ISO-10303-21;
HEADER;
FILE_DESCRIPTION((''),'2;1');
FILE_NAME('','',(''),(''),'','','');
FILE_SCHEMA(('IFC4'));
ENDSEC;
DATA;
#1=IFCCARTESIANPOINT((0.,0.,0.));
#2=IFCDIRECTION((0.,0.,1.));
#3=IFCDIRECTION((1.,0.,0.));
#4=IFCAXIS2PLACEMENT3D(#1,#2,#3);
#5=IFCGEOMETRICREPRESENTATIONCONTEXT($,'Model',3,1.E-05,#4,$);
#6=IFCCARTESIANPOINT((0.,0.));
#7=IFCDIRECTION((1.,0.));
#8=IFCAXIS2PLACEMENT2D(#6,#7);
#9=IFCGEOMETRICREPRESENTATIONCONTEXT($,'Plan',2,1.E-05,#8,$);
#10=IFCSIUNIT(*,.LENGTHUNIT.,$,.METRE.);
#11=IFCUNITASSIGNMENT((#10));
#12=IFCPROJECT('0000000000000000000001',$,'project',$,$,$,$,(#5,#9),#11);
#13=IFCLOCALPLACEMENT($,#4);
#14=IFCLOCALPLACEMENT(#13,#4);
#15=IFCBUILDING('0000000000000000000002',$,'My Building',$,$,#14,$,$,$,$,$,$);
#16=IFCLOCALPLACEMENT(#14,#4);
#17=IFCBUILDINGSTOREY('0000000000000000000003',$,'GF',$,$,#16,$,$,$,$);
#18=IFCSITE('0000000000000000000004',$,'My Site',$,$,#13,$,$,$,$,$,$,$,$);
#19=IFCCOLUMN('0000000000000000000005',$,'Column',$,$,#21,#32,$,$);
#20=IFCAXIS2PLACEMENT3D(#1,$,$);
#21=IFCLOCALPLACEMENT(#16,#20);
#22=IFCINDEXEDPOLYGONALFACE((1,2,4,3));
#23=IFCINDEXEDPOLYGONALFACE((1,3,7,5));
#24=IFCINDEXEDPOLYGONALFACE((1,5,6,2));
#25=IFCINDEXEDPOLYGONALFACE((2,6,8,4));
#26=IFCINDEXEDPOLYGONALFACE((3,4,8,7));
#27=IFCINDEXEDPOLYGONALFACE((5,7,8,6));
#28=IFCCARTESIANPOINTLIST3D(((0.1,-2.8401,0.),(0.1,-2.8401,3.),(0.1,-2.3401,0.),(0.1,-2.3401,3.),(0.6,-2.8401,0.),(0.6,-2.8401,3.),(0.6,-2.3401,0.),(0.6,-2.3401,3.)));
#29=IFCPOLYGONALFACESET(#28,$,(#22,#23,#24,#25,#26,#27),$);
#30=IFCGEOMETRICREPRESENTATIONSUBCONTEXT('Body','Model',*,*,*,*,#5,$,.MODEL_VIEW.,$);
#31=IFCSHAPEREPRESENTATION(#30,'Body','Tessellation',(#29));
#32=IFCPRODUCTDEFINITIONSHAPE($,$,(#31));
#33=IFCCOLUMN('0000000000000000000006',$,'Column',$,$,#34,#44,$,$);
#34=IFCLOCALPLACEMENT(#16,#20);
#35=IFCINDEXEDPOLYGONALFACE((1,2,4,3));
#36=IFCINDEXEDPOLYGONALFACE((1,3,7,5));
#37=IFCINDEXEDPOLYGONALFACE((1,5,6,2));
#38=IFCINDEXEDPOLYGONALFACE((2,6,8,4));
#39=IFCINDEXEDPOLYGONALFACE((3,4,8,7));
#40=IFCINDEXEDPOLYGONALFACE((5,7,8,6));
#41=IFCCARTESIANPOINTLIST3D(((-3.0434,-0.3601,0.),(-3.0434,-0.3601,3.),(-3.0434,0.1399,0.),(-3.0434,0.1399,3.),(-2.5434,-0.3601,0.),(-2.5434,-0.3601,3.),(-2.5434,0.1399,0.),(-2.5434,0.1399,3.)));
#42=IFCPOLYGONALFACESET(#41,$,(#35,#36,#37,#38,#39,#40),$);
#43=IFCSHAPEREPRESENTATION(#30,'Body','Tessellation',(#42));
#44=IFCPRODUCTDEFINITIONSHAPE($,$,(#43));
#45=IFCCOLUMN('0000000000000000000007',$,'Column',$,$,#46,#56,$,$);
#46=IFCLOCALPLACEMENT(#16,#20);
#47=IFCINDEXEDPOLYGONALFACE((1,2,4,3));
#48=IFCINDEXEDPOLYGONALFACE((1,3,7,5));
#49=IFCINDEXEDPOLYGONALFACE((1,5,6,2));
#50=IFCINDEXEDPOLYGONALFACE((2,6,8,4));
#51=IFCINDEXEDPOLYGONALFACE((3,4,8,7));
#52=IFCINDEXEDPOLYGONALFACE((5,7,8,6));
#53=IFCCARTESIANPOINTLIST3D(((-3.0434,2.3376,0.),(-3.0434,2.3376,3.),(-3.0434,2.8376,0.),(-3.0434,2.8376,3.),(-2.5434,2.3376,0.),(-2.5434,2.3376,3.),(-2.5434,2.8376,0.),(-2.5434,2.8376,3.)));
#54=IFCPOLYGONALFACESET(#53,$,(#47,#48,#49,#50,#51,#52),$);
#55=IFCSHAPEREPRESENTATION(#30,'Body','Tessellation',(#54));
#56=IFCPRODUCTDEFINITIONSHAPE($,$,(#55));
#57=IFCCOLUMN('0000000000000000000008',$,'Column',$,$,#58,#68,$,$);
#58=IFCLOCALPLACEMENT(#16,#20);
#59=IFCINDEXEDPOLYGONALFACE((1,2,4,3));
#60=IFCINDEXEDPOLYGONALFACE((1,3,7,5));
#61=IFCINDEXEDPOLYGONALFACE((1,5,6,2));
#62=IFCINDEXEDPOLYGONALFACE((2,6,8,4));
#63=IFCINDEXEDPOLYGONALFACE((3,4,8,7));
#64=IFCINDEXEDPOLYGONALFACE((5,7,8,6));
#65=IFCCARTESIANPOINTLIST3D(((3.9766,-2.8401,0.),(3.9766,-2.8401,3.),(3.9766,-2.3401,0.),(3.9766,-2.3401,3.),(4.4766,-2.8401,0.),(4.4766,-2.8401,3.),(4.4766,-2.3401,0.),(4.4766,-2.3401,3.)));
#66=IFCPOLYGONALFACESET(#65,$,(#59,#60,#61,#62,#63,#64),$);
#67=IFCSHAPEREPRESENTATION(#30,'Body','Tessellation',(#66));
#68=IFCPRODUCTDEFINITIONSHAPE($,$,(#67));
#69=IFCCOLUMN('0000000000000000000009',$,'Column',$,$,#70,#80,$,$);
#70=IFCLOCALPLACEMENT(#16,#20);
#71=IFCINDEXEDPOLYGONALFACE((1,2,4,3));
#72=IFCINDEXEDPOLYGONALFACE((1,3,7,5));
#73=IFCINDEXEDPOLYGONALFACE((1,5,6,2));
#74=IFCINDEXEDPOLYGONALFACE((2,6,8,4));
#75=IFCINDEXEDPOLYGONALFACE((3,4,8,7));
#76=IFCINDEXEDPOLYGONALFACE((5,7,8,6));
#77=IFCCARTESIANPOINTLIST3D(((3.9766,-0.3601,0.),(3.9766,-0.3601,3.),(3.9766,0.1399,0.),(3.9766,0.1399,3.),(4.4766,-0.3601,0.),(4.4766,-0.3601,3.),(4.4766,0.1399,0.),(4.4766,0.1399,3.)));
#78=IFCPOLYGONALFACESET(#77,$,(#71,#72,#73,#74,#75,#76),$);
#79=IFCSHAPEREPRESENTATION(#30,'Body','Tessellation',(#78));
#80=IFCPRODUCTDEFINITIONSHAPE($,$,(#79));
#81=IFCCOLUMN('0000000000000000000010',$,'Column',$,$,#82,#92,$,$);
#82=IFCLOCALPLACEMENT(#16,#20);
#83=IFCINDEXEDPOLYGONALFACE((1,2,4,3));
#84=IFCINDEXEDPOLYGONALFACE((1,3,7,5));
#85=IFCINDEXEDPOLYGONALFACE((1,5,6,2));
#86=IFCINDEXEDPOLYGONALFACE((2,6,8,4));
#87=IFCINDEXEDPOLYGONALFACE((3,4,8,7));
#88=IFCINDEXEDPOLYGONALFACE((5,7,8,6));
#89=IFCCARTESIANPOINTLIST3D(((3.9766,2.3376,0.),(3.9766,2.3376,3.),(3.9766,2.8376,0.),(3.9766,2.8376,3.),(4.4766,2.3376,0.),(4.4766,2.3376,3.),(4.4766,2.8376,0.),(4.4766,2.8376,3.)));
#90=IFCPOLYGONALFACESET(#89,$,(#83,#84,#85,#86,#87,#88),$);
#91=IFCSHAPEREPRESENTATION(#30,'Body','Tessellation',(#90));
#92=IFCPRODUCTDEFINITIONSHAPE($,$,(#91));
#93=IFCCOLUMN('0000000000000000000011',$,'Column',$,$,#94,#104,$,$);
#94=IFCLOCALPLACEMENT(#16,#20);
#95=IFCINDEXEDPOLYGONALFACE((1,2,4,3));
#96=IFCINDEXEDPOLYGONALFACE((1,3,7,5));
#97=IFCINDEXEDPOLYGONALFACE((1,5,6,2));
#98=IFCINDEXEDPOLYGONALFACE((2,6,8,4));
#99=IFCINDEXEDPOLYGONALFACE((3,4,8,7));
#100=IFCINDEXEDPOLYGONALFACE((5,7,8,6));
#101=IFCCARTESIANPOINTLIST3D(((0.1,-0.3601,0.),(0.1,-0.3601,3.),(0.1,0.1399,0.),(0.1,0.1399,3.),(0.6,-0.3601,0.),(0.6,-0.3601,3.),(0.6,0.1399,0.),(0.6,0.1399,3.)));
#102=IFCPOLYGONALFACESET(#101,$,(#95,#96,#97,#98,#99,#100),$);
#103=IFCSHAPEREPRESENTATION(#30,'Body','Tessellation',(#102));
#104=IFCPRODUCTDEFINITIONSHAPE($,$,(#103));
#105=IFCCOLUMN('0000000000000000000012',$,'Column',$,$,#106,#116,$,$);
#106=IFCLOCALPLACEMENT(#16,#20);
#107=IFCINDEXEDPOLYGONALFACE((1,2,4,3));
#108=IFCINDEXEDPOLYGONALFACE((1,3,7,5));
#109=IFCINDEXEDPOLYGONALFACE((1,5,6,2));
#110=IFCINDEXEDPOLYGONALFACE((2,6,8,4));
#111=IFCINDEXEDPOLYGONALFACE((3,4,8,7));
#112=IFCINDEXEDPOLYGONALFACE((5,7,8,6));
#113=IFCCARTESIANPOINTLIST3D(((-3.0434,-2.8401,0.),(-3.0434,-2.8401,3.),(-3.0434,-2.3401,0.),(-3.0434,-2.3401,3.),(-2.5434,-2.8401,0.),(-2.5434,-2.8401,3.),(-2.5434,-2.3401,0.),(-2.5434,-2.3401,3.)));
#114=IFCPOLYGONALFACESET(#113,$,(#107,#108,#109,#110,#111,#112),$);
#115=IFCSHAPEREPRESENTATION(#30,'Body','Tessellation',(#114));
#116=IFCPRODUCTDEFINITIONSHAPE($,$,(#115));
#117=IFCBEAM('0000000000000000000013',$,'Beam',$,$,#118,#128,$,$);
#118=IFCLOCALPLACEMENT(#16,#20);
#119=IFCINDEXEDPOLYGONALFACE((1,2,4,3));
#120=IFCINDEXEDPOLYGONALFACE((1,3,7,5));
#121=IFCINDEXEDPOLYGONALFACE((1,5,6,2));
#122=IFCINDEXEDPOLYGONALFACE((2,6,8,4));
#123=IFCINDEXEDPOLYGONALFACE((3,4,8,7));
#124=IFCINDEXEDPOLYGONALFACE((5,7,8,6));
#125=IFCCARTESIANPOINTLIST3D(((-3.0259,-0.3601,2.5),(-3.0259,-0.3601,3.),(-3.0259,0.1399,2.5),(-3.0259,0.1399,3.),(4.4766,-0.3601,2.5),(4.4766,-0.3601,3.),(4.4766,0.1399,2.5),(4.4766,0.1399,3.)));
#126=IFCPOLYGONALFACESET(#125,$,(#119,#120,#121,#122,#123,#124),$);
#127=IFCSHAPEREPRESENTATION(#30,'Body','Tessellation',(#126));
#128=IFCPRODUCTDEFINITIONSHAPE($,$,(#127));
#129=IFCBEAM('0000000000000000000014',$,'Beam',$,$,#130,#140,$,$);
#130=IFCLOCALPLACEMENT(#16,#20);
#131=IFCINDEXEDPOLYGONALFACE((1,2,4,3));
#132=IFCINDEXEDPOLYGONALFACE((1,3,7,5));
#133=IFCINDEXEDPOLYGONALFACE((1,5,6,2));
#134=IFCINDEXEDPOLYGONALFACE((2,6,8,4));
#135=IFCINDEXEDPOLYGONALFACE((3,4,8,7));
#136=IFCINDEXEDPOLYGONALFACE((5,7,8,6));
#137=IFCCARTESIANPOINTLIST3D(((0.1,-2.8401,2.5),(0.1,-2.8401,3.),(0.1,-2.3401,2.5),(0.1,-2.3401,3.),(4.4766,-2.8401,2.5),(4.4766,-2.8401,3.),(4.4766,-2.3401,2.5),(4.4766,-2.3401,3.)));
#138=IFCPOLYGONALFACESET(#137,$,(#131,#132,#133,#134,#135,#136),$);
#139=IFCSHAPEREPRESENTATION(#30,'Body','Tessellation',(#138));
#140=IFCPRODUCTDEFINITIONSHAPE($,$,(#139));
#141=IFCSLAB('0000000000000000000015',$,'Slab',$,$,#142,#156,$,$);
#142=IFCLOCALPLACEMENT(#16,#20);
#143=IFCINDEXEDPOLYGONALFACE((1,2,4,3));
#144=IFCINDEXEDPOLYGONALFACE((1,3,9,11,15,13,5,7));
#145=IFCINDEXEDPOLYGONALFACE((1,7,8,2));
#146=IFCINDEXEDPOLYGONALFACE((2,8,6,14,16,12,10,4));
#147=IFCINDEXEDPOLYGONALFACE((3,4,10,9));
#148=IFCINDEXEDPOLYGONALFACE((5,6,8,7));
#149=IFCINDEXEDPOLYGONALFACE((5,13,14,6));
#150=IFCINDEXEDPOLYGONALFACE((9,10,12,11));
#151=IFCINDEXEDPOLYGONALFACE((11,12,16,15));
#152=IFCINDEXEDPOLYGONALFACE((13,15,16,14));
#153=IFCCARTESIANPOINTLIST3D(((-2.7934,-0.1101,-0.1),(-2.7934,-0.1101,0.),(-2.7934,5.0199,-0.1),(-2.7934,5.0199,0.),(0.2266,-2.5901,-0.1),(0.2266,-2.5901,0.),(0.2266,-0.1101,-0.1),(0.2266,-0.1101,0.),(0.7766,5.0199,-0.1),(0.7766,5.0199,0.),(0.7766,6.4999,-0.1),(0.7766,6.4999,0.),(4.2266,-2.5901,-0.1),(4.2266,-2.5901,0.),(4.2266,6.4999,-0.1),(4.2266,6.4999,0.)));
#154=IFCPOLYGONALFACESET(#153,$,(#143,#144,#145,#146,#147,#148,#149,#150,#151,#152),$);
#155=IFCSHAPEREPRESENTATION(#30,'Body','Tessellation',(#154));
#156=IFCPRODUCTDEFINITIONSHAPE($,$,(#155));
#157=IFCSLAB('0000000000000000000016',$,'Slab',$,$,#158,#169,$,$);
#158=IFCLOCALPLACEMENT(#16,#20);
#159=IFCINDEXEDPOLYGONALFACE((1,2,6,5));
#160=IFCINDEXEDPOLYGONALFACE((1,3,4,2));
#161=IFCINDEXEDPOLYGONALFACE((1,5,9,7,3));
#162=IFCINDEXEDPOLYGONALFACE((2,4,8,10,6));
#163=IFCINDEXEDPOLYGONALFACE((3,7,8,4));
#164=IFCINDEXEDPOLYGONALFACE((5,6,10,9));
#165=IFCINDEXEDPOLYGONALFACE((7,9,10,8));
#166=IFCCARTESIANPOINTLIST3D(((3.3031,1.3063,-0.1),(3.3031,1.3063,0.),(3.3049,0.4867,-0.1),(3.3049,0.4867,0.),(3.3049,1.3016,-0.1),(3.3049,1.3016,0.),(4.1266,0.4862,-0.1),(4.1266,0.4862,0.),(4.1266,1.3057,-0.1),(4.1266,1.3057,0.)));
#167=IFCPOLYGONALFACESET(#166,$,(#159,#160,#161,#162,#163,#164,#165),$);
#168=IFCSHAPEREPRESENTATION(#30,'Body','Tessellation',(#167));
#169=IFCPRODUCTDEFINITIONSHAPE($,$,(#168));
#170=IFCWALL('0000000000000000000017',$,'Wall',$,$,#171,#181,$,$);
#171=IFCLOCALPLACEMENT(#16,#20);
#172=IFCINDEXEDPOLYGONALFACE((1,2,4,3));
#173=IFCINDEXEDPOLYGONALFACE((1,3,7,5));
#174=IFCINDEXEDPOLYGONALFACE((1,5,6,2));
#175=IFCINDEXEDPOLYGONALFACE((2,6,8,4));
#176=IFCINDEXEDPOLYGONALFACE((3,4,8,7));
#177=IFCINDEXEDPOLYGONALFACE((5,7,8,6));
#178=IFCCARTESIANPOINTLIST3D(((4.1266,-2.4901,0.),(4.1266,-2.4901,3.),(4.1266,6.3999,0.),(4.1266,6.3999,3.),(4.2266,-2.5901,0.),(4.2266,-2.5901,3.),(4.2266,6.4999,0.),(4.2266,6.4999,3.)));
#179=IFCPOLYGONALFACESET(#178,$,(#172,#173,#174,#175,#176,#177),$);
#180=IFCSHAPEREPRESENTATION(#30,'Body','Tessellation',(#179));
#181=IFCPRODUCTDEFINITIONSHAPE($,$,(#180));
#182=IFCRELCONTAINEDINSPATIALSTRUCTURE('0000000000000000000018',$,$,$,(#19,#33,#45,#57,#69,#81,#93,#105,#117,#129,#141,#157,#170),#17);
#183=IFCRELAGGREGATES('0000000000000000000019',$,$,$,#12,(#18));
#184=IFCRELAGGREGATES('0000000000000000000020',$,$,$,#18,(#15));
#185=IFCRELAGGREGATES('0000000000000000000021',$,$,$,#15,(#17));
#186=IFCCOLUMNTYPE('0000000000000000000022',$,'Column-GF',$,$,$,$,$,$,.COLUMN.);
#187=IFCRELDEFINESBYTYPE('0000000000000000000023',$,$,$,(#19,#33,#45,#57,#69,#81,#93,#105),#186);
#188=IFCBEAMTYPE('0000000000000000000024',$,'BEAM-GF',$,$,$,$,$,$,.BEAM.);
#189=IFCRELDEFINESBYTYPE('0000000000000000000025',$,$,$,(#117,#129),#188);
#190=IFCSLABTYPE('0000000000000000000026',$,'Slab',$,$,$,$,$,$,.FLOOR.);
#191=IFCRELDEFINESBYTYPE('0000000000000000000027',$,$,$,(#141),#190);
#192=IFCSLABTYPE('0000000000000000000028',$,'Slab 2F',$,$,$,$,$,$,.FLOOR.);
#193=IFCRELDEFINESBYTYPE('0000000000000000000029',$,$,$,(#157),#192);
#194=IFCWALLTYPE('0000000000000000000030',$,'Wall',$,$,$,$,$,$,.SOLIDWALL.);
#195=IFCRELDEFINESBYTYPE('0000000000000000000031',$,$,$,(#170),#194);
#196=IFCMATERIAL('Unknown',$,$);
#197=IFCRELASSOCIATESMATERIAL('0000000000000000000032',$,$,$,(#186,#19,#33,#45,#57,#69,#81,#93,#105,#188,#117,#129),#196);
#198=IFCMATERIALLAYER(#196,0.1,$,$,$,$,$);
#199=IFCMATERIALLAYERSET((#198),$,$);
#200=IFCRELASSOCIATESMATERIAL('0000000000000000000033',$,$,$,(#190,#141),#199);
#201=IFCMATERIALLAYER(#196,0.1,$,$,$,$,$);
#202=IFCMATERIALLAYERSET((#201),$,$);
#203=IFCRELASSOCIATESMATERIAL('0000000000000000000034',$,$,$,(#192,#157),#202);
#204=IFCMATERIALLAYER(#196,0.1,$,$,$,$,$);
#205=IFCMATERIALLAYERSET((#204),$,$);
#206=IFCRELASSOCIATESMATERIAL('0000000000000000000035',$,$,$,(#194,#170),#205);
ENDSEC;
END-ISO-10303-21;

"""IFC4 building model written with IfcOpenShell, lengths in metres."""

from ifc_helpers import new_model, si_unit, frame, origin_with_axes, origin_2d_with_axis, place, context, subcontext, project, spatial, line, indexed_curve, rectangle, outline, extrude, material, layer, layer_set, layer_usage, material_profile, profile_set, profile_usage, type_object, element, save


model = new_model("IFC4")

# Units and contexts
model_context = context("Model", 3, precision=1e-05, world=origin_with_axes())
plan_context = context("Plan", 2, precision=1e-05, world=origin_2d_with_axis())
body_context_1 = subcontext(model_context, "Body", "Model", "MODEL_VIEW")
ifc_project = project(units=[si_unit("LENGTHUNIT", "METRE")], contexts=[model_context, plan_context])

# Site, building, storey
site_placement = place(None, origin_with_axes())
site = spatial("IfcSite", under=ifc_project, at=site_placement, Name="My Site")
building_placement = place(site_placement, origin_with_axes())
building = spatial("IfcBuilding", under=site, at=building_placement, Name="My Building")
storey_placement = place(building_placement, origin_with_axes())
storey = spatial("IfcBuildingStorey", under=building, at=storey_placement, Name="GF")

# Columns
ifc_material = material(Name="Unknown")
ifc_material_profile_1 = material_profile(ifc_material, rectangle(XDim=0.5, YDim=0.5))
ifc_profile_set_1 = profile_set([ifc_material_profile_1])
ifc_profile_usage_1 = profile_usage(ifc_profile_set_1, cardinal=5)
column_type = type_object("IfcColumnType", Name="Column-GF", PredefinedType="COLUMN", material=ifc_profile_set_1)
column_1_placement = place(storey_placement, frame((0.35, -2.5901, 0.0), z_axis=(0.0, 0.0, 1.0), x_axis=(1.0, 0.0, 0.0)))
element("IfcColumn", 1, at=column_1_placement, inside=storey, type_object=column_type, material=ifc_profile_usage_1, Name="Column", context=body_context_1, shape_type="SweptSolid", body=[
    extrude(rectangle(XDim=0.5, YDim=0.5), origin_with_axes(), (0.0, 0.0, 1.0), 3.0),
])
ifc_profile_usage_2 = profile_usage(ifc_profile_set_1, cardinal=5)
column_2_placement = place(storey_placement, frame((-2.7934, -0.1101, 0.0), z_axis=(0.0, 0.0, 1.0), x_axis=(1.0, 0.0, 0.0)))
element("IfcColumn", 2, at=column_2_placement, inside=storey, type_object=column_type, material=ifc_profile_usage_2, Name="Column", context=body_context_1, shape_type="SweptSolid", body=[
    extrude(rectangle(XDim=0.5, YDim=0.5), origin_with_axes(), (0.0, 0.0, 1.0), 3.0),
])
ifc_profile_usage_3 = profile_usage(ifc_profile_set_1, cardinal=5)
column_3_placement = place(storey_placement, frame((-2.7934, 2.5876, 0.0), z_axis=(0.0, 0.0, 1.0), x_axis=(1.0, 0.0, 0.0)))
element("IfcColumn", 3, at=column_3_placement, inside=storey, type_object=column_type, material=ifc_profile_usage_3, Name="Column", context=body_context_1, shape_type="SweptSolid", body=[
    extrude(rectangle(XDim=0.5, YDim=0.5), origin_with_axes(), (0.0, 0.0, 1.0), 3.0),
])
ifc_profile_usage_4 = profile_usage(ifc_profile_set_1, cardinal=5)
column_4_placement = place(storey_placement, frame((4.2266, -2.5901, 0.0), z_axis=(0.0, 0.0, 1.0), x_axis=(1.0, 0.0, 0.0)))
element("IfcColumn", 4, at=column_4_placement, inside=storey, type_object=column_type, material=ifc_profile_usage_4, Name="Column", context=body_context_1, shape_type="SweptSolid", body=[
    extrude(rectangle(XDim=0.5, YDim=0.5), origin_with_axes(), (0.0, 0.0, 1.0), 3.0),
])
ifc_profile_usage_5 = profile_usage(ifc_profile_set_1, cardinal=5)
column_5_placement = place(storey_placement, frame((4.2266, -0.1101, 0.0), z_axis=(0.0, 0.0, 1.0), x_axis=(1.0, 0.0, 0.0)))
element("IfcColumn", 5, at=column_5_placement, inside=storey, type_object=column_type, material=ifc_profile_usage_5, Name="Column", context=body_context_1, shape_type="SweptSolid", body=[
    extrude(rectangle(XDim=0.5, YDim=0.5), origin_with_axes(), (0.0, 0.0, 1.0), 3.0),
])
ifc_profile_usage_6 = profile_usage(ifc_profile_set_1, cardinal=5)
column_6_placement = place(storey_placement, frame((4.2266, 2.5876, 0.0), z_axis=(0.0, 0.0, 1.0), x_axis=(1.0, 0.0, 0.0)))
element("IfcColumn", 6, at=column_6_placement, inside=storey, type_object=column_type, material=ifc_profile_usage_6, Name="Column", context=body_context_1, shape_type="SweptSolid", body=[
    extrude(rectangle(XDim=0.5, YDim=0.5), origin_with_axes(), (0.0, 0.0, 1.0), 3.0),
])
ifc_profile_usage_7 = profile_usage(ifc_profile_set_1, cardinal=5)
column_7_placement = place(storey_placement, frame((0.35, -0.1101, 0.0), z_axis=(0.0, 0.0, 1.0), x_axis=(1.0, 0.0, 0.0)))
element("IfcColumn", 7, at=column_7_placement, inside=storey, type_object=column_type, material=ifc_profile_usage_7, Name="Column", context=body_context_1, shape_type="SweptSolid", body=[
    extrude(rectangle(XDim=0.5, YDim=0.5), origin_with_axes(), (0.0, 0.0, 1.0), 3.0),
])
ifc_profile_usage_8 = profile_usage(ifc_profile_set_1, cardinal=5)
column_8_placement = place(storey_placement, frame((-2.7934, -2.5901, 0.0), z_axis=(0.0, 0.0, 1.0), x_axis=(1.0, 0.0, 0.0)))
element("IfcColumn", 8, at=column_8_placement, inside=storey, type_object=column_type, material=ifc_profile_usage_8, Name="Column", context=body_context_1, shape_type="SweptSolid", body=[
    extrude(rectangle(XDim=0.5, YDim=0.5), origin_with_axes(), (0.0, 0.0, 1.0), 3.0),
])

# Beams
ifc_material_profile_2 = material_profile(ifc_material, rectangle(XDim=0.5, YDim=0.5))
ifc_profile_set_2 = profile_set([ifc_material_profile_2])
ifc_profile_usage_9 = profile_usage(ifc_profile_set_2, cardinal=7)
beam_type = type_object("IfcBeamType", Name="BEAM-GF", PredefinedType="BEAM", material=ifc_profile_set_2)
beam_1_placement = place(storey_placement, frame((-3.0259, 0.1399, 3.0), z_axis=(1.0, 0.0, 0.0), x_axis=(0.0, 1.0, 0.0)))
element("IfcBeam", 9, at=beam_1_placement, inside=storey, type_object=beam_type, material=ifc_profile_usage_9, Name="Beam", context=body_context_1, shape_type="SweptSolid", body=[
    extrude(rectangle(XDim=0.5, YDim=0.5), frame((-0.25, -0.25, 0.0), z_axis=(0.0, 0.0, 1.0), x_axis=(1.0, 0.0, 0.0)), (0.0, 0.0, 1.0), 7.5025),
])
ifc_profile_usage_10 = profile_usage(ifc_profile_set_2, cardinal=7)
beam_2_placement = place(storey_placement, frame((0.1, -2.3401, 3.0), z_axis=(1.0, 0.0, 0.0), x_axis=(0.0, 1.0, 0.0)))
element("IfcBeam", 10, at=beam_2_placement, inside=storey, type_object=beam_type, material=ifc_profile_usage_10, Name="Beam", context=body_context_1, shape_type="SweptSolid", body=[
    extrude(rectangle(XDim=0.5, YDim=0.5), frame((-0.25, -0.25, 0.0), z_axis=(0.0, 0.0, 1.0), x_axis=(1.0, 0.0, 0.0)), (0.0, 0.0, 1.0), 4.3766),
])

# Slabs
ifc_layer_1 = layer(ifc_material, 0.1)
ifc_layer_set_1 = layer_set([ifc_layer_1])
ifc_layer_usage_1 = layer_usage(ifc_layer_set_1, "AXIS3", "POSITIVE", -0.1)
slab_type_1 = type_object("IfcSlabType", Name="Slab", PredefinedType="FLOOR", material=ifc_layer_set_1)
slab_1_placement = place(storey_placement, frame((4.2266, -2.5901, 0.0), z_axis=(0.0, 0.0, 1.0), x_axis=(1.0, 0.0, 0.0)))
element("IfcSlab", 11, at=slab_1_placement, inside=storey, type_object=slab_type_1, material=ifc_layer_usage_1, Name="Slab", context=body_context_1, shape_type="SweptSolid", body=[
    extrude(outline(indexed_curve([(0.0, 0.0), (0.0, 9.09), (-3.45, 9.09), (-3.45, 7.61), (-7.02, 7.61), (-7.02, 2.48), (-4.0, 2.48), (-4.0, 0.0), (0.0, 0.0)])), frame((0.0, 0.0, -0.1), z_axis=(0.0, 0.0, 1.0), x_axis=(1.0, 0.0, 0.0)), (0.0, 0.0, 1.0), 0.1),
])
ifc_layer_2 = layer(ifc_material, 0.1)
ifc_layer_set_2 = layer_set([ifc_layer_2])
ifc_layer_usage_2 = layer_usage(ifc_layer_set_2, "AXIS3", "POSITIVE", -0.1)
slab_type_2 = type_object("IfcSlabType", Name="Slab 2F", PredefinedType="FLOOR", material=ifc_layer_set_2)
slab_2_placement = place(storey_placement, frame((3.3031, 1.3063, 0.0), z_axis=(0.0, 0.0, 1.0), x_axis=(1.0, 0.0, 0.0)))
element("IfcSlab", 12, at=slab_2_placement, inside=storey, type_object=slab_type_2, material=ifc_layer_usage_2, Name="Slab", context=body_context_1, shape_type="SweptSolid", body=[
    extrude(outline(indexed_curve([(0.0, 0.0), (0.0018, -0.8196), (0.8235, -0.8201), (0.8235, -0.0005), (0.0018, -0.0047), (0.0, 0.0)])), frame((0.0, 0.0, -0.1), z_axis=(0.0, 0.0, 1.0), x_axis=(1.0, 0.0, 0.0)), (0.0, 0.0, 1.0), 0.1),
])

# Shared definitions
ifc_layer_3 = layer(ifc_material, 0.1)
ifc_layer_set_3 = layer_set([ifc_layer_3])
wall_type = type_object("IfcWallType", Name="Wall", PredefinedType="SOLIDWALL", material=ifc_layer_set_3)

# Wall
ifc_layer_usage_3 = layer_usage(ifc_layer_set_3, "AXIS2", "POSITIVE", 0.0)
wall_1_placement = place(storey_placement, frame((4.2266, -2.5901, 0.0), z_axis=(0.0, 0.0, 1.0), x_axis=(0.0, 1.0, 0.0)))
element("IfcWall", 13, at=wall_1_placement, inside=storey, type_object=wall_type, material=ifc_layer_usage_3, Name="Wall", context=body_context_1, shape_type="SweptSolid", body=[
    extrude(outline(indexed_curve([(0.0, 0.0), (0.1, 0.1), (8.99, 0.1), (9.09, 0.0)], segments=[line(1, 2, 3, 4, 1)])), origin_with_axes(), (0.0, 0.0, 1.0), 3.0),
])

save(model, "model.ifc")
